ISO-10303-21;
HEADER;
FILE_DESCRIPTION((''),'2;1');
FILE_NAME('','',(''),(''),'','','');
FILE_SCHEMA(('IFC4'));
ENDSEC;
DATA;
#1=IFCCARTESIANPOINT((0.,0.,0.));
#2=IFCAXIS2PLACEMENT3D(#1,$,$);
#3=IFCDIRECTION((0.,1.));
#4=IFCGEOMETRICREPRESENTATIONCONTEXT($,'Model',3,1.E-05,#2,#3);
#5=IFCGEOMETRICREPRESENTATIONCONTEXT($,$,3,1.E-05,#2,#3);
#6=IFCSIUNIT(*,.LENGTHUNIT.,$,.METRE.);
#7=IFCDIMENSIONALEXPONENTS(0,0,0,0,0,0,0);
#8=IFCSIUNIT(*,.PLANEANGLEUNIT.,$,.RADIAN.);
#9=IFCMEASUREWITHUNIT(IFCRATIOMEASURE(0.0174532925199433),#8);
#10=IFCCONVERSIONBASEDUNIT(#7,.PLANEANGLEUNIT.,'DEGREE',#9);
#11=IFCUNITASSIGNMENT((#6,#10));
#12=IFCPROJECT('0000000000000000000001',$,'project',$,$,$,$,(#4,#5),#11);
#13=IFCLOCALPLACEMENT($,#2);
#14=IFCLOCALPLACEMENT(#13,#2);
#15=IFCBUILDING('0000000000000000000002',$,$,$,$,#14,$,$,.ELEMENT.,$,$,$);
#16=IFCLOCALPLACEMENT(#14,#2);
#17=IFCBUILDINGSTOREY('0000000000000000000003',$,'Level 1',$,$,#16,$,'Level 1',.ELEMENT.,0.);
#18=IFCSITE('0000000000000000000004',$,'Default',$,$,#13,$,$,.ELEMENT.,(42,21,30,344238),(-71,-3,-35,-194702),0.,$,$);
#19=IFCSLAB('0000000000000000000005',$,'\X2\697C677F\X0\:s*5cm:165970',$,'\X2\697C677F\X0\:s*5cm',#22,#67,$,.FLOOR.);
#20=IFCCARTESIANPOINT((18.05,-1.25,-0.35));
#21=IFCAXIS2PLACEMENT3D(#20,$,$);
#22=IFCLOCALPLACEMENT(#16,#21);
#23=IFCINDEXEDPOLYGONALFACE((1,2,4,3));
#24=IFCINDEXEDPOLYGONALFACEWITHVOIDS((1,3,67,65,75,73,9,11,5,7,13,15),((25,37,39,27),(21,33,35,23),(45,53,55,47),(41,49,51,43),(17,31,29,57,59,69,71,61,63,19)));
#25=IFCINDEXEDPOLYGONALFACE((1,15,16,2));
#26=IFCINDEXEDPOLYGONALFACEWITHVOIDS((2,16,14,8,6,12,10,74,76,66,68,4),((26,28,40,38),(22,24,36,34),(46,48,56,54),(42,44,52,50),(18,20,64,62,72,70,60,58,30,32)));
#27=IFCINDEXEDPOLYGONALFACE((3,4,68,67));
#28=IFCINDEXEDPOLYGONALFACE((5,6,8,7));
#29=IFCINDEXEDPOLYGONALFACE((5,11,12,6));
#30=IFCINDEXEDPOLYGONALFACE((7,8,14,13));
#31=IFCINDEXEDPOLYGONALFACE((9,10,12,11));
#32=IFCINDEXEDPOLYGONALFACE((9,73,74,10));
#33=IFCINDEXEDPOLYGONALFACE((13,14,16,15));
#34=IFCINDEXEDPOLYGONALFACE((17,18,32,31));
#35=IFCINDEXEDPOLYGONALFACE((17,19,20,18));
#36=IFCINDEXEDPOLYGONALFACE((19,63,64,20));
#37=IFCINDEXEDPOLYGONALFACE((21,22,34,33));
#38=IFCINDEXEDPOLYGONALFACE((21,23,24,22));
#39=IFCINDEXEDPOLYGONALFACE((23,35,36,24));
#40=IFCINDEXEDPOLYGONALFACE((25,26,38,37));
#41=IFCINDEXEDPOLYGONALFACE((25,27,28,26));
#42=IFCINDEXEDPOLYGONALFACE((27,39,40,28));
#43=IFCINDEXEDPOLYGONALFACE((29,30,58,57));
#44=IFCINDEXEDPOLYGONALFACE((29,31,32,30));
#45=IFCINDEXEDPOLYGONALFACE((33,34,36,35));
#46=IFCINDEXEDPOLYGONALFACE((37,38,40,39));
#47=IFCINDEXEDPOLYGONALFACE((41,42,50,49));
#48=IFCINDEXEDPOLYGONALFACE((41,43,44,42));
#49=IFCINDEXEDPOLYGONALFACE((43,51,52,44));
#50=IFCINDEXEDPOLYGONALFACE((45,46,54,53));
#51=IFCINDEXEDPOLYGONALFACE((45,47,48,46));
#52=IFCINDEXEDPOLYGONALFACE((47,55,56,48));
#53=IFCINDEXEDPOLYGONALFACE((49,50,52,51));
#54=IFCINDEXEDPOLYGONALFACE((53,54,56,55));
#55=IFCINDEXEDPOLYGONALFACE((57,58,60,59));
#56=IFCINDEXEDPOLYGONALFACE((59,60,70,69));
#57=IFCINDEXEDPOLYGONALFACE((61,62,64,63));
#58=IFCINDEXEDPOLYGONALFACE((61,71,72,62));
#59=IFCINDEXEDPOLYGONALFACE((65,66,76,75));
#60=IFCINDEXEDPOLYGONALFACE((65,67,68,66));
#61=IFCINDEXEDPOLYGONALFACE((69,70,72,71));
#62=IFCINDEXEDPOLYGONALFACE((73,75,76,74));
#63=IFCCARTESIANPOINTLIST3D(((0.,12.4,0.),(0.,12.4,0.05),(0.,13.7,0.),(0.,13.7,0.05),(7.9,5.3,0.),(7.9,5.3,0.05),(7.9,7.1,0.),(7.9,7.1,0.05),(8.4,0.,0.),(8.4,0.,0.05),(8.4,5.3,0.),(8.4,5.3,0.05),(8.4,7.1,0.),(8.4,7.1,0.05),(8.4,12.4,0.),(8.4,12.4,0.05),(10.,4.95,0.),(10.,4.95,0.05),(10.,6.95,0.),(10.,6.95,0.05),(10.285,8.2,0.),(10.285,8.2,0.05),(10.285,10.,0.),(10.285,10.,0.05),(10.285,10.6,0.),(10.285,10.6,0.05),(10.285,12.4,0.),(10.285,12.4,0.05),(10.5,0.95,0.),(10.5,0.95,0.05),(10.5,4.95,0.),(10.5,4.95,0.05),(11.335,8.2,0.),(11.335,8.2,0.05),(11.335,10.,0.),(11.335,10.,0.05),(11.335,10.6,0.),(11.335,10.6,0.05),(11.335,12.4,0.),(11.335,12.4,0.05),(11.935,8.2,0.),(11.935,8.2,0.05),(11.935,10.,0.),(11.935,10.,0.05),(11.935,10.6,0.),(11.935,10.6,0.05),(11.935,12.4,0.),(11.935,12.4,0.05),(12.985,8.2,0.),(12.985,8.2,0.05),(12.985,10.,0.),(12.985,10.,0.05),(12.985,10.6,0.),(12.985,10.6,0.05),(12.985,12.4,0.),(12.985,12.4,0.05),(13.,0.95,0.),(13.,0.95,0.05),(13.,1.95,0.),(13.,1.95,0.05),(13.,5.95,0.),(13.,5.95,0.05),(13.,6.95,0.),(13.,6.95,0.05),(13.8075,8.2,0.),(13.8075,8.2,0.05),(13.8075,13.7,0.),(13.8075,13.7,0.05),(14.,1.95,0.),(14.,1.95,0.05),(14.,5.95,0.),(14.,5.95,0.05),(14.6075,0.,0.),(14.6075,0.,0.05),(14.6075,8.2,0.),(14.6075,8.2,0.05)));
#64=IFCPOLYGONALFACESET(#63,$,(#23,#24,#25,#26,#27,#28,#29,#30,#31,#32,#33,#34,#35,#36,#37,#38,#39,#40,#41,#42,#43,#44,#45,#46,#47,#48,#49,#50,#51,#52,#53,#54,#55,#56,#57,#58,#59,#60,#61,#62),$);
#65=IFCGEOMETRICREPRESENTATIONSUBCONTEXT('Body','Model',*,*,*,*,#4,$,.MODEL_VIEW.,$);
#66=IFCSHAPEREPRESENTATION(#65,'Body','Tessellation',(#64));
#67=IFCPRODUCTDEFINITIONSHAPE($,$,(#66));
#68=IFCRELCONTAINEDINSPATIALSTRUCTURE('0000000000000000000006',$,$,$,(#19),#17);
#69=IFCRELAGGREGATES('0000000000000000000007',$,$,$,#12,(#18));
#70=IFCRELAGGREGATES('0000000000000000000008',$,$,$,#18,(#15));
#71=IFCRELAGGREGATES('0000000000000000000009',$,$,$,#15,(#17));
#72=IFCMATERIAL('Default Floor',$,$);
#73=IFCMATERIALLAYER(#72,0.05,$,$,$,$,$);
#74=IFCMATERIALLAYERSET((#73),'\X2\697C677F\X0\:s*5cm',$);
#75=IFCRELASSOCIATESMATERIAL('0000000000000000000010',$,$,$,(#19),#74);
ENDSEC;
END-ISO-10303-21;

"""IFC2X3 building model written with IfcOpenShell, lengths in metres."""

from ifc_helpers import new_model, entity, si_unit, converted_unit, direction, frame, origin, origin_2d_with_axis, place, context, subcontext, project, spatial, polyline, rectangle, outline, extrude, material, layer, layer_set, layer_usage, element, save


model = new_model("IFC2X3")

# Units and contexts
model_context = context("Model", 3, precision=1e-05, world=origin(), true_north=direction((0.0, 1.0)))
context_of_model = context(None, 3, precision=1e-05, world=origin(), true_north=direction((0.0, 1.0)))
body_context = subcontext(model_context, "Body", "Model", "MODEL_VIEW")
ifc_project = project(units=[si_unit("LENGTHUNIT", "METRE"), converted_unit("PLANEANGLEUNIT", "DEGREE", entity("IfcRatioMeasure", 0.0174532925199433), si_unit("PLANEANGLEUNIT", "RADIAN"), dimensions=[0, 0, 0, 0, 0, 0, 0])], contexts=[model_context, context_of_model])

# Site, building, storey
site_placement = place(None, origin())
site = spatial("IfcSite", under=ifc_project, at=site_placement, Name="Default", CompositionType="ELEMENT", RefLatitude=(42, 21, 30, 344238), RefLongitude=(-71, -3, -35, -194702), RefElevation=0.0)
building_placement = place(site_placement, origin())
building = spatial("IfcBuilding", under=site, at=building_placement, CompositionType="ELEMENT")
storey_placement = place(building_placement, origin())
storey = spatial("IfcBuildingStorey", under=building, at=storey_placement, Name="Level 1", LongName="Level 1", CompositionType="ELEMENT", Elevation=0.0)

# Slab, openings
ifc_material_1 = material(Name="Default Floor")
ifc_layer_1 = layer(ifc_material_1, 0.05)
ifc_layer_set_1 = layer_set([ifc_layer_1], Name="楼板:s*5cm")
ifc_layer_usage_1 = layer_usage(ifc_layer_set_1, "AXIS3", "POSITIVE", 0.0)
slab_placement = place(storey_placement, frame((18.05, -1.25, -0.35)))
slab = element("IfcSlab", 1, at=slab_placement, inside=storey, material=ifc_layer_usage_1, Name="楼板:s*5cm:165970", ObjectType="楼板:s*5cm", PredefinedType="FLOOR", context=body_context, shape_type="SweptSolid", body=[
    extrude(outline(polyline([(7.3037, 6.85), (-6.5037, 6.85), (-6.5037, 1.35), (-7.3037, 1.35), (-7.3037, -6.85), (-1.0963, -6.85), (-1.0963, -1.55), (-0.5963, -1.55), (-0.5963, 0.25), (-1.0963, 0.25), (-1.0963, 5.55), (7.3037, 5.55), (7.3037, 6.85)])), frame((7.3037, 6.85, 0.05), z_axis=(0.0, 0.0, -1.0), x_axis=(-1.0, 0.0, 0.0)), (0.0, 0.0, 1.0), 0.05),
])
opening_1_placement = place(slab_placement, frame((12.46, 11.5, 0.05)))
element("IfcOpeningElement", 2, at=opening_1_placement, cuts=slab, ObjectType="Opening", context=body_context, shape_type="SweptSolid", body=[
    extrude(rectangle(XDim=1.8, YDim=1.05, at=origin_2d_with_axis()), frame((0.0, 0.0, 0.0), z_axis=(0.0, 0.0, -1.0), x_axis=(0.0, 1.0, 0.0)), (0.0, 0.0, 1.0), 0.05),
])
opening_2_placement = place(slab_placement, frame((10.81, 11.5, 0.05)))
element("IfcOpeningElement", 3, at=opening_2_placement, cuts=slab, ObjectType="Opening", context=body_context, shape_type="SweptSolid", body=[
    extrude(rectangle(XDim=1.05, YDim=1.8, at=origin_2d_with_axis()), frame((0.0, 0.0, 0.0), z_axis=(0.0, 0.0, -1.0), x_axis=(1.0, 0.0, 0.0)), (0.0, 0.0, 1.0), 0.05),
])
opening_3_placement = place(slab_placement, frame((10.81, 9.1, 0.05)))
element("IfcOpeningElement", 4, at=opening_3_placement, cuts=slab, ObjectType="Opening", context=body_context, shape_type="SweptSolid", body=[
    extrude(rectangle(XDim=1.8, YDim=1.05, at=origin_2d_with_axis()), frame((0.0, 0.0, 0.0), z_axis=(0.0, 0.0, 1.0), x_axis=(0.0, -1.0, 0.0)), (0.0, 0.0, -1.0), 0.05),
])
opening_4_placement = place(slab_placement, frame((12.46, 9.1, 0.05)))
element("IfcOpeningElement", 5, at=opening_4_placement, cuts=slab, ObjectType="Opening", context=body_context, shape_type="SweptSolid", body=[
    extrude(rectangle(XDim=1.05, YDim=1.8, at=origin_2d_with_axis()), frame((0.0, 0.0, 0.0), z_axis=(0.0, 0.0, -1.0), x_axis=(-1.0, 0.0, 0.0)), (0.0, 0.0, 1.0), 0.05),
])
opening_5_placement = place(slab_placement, frame((12.1, 4.15, 0.05)))
element("IfcOpeningElement", 6, at=opening_5_placement, cuts=slab, ObjectType="Opening", context=body_context, shape_type="SweptSolid", body=[
    extrude(outline(polyline([(0.8, -2.1), (2.8, -2.1), (2.8, 0.9), (1.8, 0.9), (1.8, 1.9), (-2.2, 1.9), (-2.2, 0.9), (-3.2, 0.9), (-3.2, -1.6), (0.8, -1.6), (0.8, -2.1)])), frame((0.0, 0.0, 0.0), z_axis=(0.0, 0.0, -1.0), x_axis=(0.0, 1.0, 0.0)), (0.0, 0.0, 1.0), 0.05),
])

save(model, "model.ifc")
